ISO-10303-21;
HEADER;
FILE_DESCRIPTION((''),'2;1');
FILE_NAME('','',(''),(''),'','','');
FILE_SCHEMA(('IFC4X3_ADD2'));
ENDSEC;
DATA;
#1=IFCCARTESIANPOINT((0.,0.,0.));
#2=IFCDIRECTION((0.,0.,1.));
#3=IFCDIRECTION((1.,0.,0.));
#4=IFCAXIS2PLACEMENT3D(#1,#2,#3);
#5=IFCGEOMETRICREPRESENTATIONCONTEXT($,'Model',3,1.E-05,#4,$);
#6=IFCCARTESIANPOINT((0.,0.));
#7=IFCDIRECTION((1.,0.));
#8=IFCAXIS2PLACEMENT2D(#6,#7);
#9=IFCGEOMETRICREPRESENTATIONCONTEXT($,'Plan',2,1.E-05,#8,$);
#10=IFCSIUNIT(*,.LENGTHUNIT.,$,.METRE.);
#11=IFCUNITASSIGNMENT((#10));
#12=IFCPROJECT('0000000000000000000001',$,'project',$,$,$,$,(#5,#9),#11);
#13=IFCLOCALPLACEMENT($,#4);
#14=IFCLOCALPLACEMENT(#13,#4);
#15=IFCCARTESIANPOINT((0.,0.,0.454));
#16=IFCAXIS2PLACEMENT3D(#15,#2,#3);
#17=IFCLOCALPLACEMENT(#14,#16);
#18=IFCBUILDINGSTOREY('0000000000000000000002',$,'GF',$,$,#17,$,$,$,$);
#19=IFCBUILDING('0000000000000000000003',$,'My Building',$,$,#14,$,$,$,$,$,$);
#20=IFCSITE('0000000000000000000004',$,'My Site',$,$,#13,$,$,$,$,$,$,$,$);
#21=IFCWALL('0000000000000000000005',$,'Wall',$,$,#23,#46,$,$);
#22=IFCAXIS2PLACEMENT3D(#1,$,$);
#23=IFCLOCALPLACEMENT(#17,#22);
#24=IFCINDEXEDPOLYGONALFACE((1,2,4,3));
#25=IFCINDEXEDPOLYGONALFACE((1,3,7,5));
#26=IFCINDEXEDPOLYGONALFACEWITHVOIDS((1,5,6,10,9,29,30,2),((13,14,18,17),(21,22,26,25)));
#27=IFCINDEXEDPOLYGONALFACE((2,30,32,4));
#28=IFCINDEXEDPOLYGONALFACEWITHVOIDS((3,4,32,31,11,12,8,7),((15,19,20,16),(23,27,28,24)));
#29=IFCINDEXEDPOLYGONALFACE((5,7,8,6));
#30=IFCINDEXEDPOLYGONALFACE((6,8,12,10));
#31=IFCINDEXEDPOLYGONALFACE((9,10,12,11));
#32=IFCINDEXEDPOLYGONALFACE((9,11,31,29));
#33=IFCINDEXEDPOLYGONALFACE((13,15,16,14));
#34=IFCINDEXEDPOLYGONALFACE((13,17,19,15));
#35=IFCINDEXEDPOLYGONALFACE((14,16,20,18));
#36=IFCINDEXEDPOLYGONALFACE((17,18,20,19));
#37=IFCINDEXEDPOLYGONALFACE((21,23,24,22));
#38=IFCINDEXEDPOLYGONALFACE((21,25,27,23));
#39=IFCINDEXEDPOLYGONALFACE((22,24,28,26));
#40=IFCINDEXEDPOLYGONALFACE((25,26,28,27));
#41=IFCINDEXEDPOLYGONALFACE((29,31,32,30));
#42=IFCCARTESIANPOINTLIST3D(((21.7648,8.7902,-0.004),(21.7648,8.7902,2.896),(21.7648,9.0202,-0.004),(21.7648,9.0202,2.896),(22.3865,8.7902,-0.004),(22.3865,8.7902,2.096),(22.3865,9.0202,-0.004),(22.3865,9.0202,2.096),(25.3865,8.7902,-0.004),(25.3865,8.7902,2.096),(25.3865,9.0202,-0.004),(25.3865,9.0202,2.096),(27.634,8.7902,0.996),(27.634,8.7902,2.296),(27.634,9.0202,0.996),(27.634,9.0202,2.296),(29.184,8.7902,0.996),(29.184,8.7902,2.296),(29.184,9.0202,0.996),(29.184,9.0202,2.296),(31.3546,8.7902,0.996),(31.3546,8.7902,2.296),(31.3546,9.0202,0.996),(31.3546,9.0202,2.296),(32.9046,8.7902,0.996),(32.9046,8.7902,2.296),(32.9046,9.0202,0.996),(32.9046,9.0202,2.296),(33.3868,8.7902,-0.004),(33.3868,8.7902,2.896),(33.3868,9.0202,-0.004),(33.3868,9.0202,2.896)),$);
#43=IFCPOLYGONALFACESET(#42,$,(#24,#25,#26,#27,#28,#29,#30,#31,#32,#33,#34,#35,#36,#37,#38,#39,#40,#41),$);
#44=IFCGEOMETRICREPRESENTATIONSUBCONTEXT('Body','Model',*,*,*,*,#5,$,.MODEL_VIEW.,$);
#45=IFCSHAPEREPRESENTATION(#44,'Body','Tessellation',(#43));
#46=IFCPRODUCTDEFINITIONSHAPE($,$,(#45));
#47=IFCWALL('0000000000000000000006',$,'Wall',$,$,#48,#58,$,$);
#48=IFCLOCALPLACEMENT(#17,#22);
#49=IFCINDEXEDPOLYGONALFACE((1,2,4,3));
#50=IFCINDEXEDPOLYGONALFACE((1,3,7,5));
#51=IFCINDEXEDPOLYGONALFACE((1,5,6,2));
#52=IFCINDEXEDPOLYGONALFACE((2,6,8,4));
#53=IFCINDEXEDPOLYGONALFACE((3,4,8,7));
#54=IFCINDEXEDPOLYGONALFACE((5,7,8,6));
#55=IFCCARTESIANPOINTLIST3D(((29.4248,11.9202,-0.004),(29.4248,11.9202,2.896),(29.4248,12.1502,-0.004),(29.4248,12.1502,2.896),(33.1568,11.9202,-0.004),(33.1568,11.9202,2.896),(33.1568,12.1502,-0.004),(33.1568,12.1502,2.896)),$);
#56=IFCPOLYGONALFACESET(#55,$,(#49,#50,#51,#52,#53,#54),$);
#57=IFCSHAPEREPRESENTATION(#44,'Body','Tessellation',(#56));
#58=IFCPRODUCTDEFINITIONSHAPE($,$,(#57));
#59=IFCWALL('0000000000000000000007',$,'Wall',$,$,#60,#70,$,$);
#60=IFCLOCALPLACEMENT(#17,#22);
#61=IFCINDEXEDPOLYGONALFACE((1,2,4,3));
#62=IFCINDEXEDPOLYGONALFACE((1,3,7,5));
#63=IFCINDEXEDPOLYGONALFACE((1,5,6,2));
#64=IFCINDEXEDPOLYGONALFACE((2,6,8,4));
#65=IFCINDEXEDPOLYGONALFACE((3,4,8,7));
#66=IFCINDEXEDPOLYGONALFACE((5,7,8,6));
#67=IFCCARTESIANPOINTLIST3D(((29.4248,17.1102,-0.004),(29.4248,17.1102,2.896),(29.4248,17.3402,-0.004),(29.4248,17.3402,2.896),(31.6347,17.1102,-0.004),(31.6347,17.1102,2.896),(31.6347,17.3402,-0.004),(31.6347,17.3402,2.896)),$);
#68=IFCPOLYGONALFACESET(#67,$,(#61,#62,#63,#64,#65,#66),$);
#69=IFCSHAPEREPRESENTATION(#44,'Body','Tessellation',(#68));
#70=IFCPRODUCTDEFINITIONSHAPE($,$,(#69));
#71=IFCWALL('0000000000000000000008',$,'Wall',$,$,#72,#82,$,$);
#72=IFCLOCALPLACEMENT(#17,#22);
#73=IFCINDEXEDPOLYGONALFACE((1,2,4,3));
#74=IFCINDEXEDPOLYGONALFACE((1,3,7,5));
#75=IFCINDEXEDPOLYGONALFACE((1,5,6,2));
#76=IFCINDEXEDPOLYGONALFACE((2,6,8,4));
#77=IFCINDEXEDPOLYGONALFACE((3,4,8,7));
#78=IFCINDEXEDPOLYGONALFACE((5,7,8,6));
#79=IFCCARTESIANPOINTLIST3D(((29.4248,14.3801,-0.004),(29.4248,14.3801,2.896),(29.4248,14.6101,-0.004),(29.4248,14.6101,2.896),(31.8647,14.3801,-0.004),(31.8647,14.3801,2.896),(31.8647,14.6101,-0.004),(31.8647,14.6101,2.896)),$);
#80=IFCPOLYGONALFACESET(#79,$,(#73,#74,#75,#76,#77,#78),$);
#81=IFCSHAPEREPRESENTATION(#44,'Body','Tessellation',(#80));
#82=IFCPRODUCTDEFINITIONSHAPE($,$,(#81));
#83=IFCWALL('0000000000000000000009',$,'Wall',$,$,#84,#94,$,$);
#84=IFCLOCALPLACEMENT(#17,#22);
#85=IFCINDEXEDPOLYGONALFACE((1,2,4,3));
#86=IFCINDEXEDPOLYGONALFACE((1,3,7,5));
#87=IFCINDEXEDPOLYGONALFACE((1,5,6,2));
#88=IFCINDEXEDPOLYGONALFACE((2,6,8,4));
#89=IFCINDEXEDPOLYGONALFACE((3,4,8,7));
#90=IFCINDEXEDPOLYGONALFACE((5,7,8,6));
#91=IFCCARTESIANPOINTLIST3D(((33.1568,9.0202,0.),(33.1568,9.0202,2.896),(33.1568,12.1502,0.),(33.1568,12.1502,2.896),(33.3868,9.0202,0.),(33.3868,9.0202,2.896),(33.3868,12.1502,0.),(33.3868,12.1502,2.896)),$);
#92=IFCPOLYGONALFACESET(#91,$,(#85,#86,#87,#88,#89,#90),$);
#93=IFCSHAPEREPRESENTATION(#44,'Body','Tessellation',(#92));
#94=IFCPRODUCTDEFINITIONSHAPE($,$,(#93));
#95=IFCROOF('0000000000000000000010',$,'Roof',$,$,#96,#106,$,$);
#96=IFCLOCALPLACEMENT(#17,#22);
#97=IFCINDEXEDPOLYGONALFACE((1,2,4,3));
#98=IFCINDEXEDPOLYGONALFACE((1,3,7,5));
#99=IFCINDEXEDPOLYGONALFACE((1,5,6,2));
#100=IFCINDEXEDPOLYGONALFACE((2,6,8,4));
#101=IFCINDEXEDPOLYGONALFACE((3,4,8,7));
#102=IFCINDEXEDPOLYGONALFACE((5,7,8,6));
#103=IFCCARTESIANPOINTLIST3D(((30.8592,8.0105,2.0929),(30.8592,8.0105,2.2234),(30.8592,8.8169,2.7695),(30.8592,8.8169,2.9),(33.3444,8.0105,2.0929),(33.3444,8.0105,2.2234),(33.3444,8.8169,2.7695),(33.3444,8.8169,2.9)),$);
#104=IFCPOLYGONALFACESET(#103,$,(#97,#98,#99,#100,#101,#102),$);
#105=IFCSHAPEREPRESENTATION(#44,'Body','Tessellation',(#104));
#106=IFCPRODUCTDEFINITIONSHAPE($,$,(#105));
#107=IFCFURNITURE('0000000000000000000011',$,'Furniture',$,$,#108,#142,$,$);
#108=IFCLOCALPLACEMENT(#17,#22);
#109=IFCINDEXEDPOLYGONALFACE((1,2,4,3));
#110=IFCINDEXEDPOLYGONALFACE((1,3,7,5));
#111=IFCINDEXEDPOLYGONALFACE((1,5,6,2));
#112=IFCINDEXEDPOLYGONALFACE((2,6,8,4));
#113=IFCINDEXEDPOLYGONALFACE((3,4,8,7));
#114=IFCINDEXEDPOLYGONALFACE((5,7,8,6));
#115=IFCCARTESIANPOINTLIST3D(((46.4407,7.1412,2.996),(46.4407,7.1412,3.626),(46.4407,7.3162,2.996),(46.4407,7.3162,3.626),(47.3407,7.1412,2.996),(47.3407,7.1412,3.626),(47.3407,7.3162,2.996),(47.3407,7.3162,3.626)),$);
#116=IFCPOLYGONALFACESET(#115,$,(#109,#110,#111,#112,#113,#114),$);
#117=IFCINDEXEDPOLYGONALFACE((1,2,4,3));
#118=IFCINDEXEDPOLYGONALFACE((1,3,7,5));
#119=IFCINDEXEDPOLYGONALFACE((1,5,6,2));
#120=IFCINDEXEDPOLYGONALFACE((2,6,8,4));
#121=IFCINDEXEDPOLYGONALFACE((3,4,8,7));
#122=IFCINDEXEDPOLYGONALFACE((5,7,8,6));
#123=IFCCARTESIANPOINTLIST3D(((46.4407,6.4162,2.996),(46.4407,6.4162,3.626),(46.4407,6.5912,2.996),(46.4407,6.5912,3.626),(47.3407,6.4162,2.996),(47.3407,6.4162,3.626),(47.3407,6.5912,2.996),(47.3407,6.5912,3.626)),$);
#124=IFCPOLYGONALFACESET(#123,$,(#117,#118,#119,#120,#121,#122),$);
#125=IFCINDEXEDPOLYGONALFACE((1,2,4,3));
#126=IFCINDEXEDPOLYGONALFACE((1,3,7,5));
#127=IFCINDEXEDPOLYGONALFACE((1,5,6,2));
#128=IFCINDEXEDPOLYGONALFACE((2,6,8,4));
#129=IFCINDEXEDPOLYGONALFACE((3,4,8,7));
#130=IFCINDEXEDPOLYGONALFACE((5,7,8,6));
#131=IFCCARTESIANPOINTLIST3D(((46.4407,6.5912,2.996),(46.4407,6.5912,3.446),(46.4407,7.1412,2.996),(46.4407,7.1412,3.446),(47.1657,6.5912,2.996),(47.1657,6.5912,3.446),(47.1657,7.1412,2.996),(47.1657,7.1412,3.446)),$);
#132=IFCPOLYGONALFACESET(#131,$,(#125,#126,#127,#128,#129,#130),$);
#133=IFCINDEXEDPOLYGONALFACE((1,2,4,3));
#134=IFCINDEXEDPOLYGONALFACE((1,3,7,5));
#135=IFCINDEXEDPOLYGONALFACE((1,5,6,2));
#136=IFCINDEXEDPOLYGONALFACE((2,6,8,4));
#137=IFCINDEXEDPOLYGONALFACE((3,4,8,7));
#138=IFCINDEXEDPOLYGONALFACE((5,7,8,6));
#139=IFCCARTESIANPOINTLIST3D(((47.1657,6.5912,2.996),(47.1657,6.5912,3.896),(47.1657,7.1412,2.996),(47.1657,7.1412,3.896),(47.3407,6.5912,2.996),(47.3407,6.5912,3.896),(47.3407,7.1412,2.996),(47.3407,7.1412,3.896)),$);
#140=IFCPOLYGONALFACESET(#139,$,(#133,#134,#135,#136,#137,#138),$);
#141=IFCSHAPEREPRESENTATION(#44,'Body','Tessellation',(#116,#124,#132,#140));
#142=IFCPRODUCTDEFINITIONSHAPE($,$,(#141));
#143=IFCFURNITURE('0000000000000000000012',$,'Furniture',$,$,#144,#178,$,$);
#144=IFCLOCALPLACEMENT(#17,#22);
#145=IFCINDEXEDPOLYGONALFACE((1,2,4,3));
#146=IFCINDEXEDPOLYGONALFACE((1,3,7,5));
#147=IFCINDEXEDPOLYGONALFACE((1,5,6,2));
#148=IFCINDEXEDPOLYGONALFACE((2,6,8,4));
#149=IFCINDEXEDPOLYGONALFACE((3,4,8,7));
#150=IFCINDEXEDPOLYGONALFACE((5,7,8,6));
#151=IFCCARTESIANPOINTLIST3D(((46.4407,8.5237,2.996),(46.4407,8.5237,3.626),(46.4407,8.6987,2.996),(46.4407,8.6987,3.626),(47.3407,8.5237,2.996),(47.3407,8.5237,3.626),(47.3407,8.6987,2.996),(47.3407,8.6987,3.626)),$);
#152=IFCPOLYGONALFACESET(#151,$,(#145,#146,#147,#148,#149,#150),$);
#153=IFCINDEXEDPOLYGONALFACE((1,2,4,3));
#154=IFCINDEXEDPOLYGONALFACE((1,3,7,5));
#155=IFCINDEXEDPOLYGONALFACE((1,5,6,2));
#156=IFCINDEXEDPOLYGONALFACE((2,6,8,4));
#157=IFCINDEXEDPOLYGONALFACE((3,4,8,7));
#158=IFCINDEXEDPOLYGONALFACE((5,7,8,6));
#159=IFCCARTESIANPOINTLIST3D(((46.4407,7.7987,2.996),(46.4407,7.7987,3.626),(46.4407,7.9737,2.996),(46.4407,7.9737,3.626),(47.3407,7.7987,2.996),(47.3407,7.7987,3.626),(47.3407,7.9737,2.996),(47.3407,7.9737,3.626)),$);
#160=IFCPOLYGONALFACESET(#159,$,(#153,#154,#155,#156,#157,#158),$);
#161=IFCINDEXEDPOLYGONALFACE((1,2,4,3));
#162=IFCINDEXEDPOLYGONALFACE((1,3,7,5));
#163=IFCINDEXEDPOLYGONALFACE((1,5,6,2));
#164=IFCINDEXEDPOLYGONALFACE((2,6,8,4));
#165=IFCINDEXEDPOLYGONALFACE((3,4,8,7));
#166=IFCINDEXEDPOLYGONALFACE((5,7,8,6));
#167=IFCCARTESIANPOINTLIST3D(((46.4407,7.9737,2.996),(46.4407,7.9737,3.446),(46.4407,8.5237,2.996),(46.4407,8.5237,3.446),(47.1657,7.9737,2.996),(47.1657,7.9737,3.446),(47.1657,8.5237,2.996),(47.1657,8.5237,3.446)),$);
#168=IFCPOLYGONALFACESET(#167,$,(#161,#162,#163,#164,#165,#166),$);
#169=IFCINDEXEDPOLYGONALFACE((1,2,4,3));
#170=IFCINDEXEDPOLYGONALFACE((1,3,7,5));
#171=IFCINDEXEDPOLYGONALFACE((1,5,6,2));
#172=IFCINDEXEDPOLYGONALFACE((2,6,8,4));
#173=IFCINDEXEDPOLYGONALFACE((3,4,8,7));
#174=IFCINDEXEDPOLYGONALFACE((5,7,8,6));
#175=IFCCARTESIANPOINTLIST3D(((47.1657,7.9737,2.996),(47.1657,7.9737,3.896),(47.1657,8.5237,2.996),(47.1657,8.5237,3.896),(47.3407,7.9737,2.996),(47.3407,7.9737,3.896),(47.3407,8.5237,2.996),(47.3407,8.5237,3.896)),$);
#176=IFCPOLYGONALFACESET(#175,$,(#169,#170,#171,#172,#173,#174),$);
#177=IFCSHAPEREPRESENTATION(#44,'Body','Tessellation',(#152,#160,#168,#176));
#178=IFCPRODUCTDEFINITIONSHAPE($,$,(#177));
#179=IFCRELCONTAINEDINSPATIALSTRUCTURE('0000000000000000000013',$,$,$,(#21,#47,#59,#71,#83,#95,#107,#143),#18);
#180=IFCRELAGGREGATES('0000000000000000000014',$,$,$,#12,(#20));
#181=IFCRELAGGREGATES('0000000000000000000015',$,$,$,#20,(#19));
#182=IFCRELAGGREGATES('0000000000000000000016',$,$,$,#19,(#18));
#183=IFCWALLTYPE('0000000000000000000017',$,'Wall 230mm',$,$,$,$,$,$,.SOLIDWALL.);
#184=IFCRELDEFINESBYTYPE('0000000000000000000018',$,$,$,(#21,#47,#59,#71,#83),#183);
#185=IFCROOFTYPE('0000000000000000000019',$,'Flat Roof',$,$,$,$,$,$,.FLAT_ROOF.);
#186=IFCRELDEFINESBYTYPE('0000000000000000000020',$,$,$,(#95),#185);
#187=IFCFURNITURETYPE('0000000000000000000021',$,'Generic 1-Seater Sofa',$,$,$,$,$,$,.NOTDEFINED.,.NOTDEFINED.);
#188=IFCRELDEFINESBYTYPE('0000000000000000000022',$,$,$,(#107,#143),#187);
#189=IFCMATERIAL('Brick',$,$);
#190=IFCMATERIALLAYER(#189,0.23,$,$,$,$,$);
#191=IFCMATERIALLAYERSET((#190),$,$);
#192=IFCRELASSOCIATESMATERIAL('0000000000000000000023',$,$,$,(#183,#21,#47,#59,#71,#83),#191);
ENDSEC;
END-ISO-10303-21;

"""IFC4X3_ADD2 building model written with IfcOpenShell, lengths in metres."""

from ifc_helpers import new_model, entity, si_unit, frame, origin_with_axes, origin_2d_with_axis, place, context, subcontext, project, spatial, polyline, line, indexed_curve, outline, extrude, clip, halfspace, shape, source, transform, mapped, material, layer, layer_set, layer_usage, type_object, type_shapes, element, save


model = new_model("IFC4X3_ADD2")

# Units and contexts
model_context = context("Model", 3, precision=1e-05, world=origin_with_axes())
plan_context = context("Plan", 2, precision=1e-05, world=origin_2d_with_axis())
body_context_1 = subcontext(model_context, "Body", "Model", "MODEL_VIEW")
body_context_2 = subcontext(plan_context, "Body", "Plan", "PLAN_VIEW")
ifc_project = project(units=[si_unit("LENGTHUNIT", "METRE")], contexts=[model_context, plan_context])

# Site, building, storey
site_placement = place(None, origin_with_axes())
site = spatial("IfcSite", under=ifc_project, at=site_placement, Name="My Site")
building_placement = place(site_placement, origin_with_axes())
building = spatial("IfcBuilding", under=site, at=building_placement, Name="My Building")
storey_placement = place(building_placement, frame((0.0, 0.0, 0.454), z_axis=(0.0, 0.0, 1.0), x_axis=(1.0, 0.0, 0.0)))
storey = spatial("IfcBuildingStorey", under=building, at=storey_placement, Name="GF")

# Shared definitions
ifc_material = material(Name="Brick")
ifc_layer = layer(ifc_material, 0.23)
ifc_layer_set = layer_set([ifc_layer])
wall_type = type_object("IfcWallType", Name="Wall 230mm", PredefinedType="SOLIDWALL", material=ifc_layer_set)

# Wall, openings
ifc_layer_usage_1 = layer_usage(ifc_layer_set, "AXIS2", "POSITIVE", 0.0)
wall_1_placement = place(storey_placement, frame((33.3868, 9.0202, -0.004), z_axis=(0.0, 0.0, 1.0), x_axis=(-1.0, 0.0, 0.0)))
wall_1 = element("IfcWall", 1, at=wall_1_placement, inside=storey, type_object=wall_type, material=ifc_layer_usage_1, Name="Wall", context=body_context_1, shape_type="SweptSolid", body=[
    extrude(outline(indexed_curve([(0.0, 0.0), (0.0, 0.23), (11.622, 0.23), (11.622, 0.0), (0.0, 0.0)], self_intersect=False)), origin_with_axes(), (0.0, 0.0, 1.0), 2.9),
])
shared_shape_1 = source(origin_with_axes(), body_context_1, "Body", "SweptSolid", [
    extrude(outline(indexed_curve([(0.0, 0.0), (3.0, 0.0), (3.0, 2.1), (0.0, 2.1)], segments=[line(1, 2, 3, 4, 1)])), frame((0.0, -0.6, 0.0), z_axis=(0.0, -1.0, 0.0), x_axis=(1.0, 0.0, 0.0)), (0.0, 0.0, -1.0), 1.2),
])
opening_1_placement = place(wall_1_placement, frame((8.0003, 0.0, 0.0), z_axis=(0.0, 0.0, 1.0), x_axis=(1.0, 0.0, 0.0)))
element("IfcOpeningElement", 2, at=opening_1_placement, cuts=wall_1, PredefinedType="OPENING", context=body_context_1, shape_type="MappedRepresentation", body=[
    mapped(shared_shape_1, transform((0.0, 0.0, 0.0), x_axis=(1.0, 0.0, 0.0), y_axis=(0.0, 1.0, 0.0), z_axis=(0.0, 0.0, 1.0), scale=1.0)),
])
shared_shape_2 = source(origin_with_axes(), body_context_1, "Body", "SweptSolid", [
    extrude(outline(indexed_curve([(0.0, 0.0), (1.55, 0.0), (1.55, 1.3), (0.0, 1.3)], segments=[line(1, 2, 3, 4, 1)])), frame((-0.775, -0.6, 0.0), z_axis=(0.0, -1.0, 0.0), x_axis=(1.0, 0.0, 0.0)), (0.0, 0.0, -1.0), 1.2),
])
opening_2_placement = place(wall_1_placement, frame((1.2571, 0.0, 1.0), z_axis=(0.0, 0.0, 1.0), x_axis=(1.0, 0.0, 0.0)))
element("IfcOpeningElement", 3, at=opening_2_placement, cuts=wall_1, PredefinedType="OPENING", context=body_context_1, shape_type="MappedRepresentation", body=[
    mapped(shared_shape_2, transform((0.0, 0.0, 0.0), x_axis=(1.0, 0.0, 0.0), y_axis=(0.0, 1.0, 0.0), z_axis=(0.0, 0.0, 1.0), scale=1.0)),
])
opening_3_placement = place(wall_1_placement, frame((4.9778, 0.0, 1.0), z_axis=(0.0, 0.0, 1.0), x_axis=(1.0, 0.0, 0.0)))
element("IfcOpeningElement", 4, at=opening_3_placement, cuts=wall_1, PredefinedType="OPENING", context=body_context_1, shape_type="MappedRepresentation", body=[
    mapped(shared_shape_2, transform((0.0, 0.0, 0.0), x_axis=(1.0, 0.0, 0.0), y_axis=(0.0, 1.0, 0.0), z_axis=(0.0, 0.0, 1.0), scale=1.0)),
])

# Walls
ifc_layer_usage_2 = layer_usage(ifc_layer_set, "AXIS2", "POSITIVE", 0.0)
wall_2_placement = place(storey_placement, frame((33.1568, 12.1502, -0.004), z_axis=(0.0, 0.0, 1.0), x_axis=(-1.0, 0.0, 0.0)))
element("IfcWall", 5, at=wall_2_placement, inside=storey, type_object=wall_type, material=ifc_layer_usage_2, Name="Wall", context=body_context_1, shape_type="SweptSolid", body=[
    extrude(outline(indexed_curve([(0.0, 0.0), (0.0, 0.23), (3.732, 0.23), (3.732, 0.0), (0.0, 0.0)], self_intersect=False)), origin_with_axes(), (0.0, 0.0, 1.0), 2.9),
])
ifc_layer_usage_3 = layer_usage(ifc_layer_set, "AXIS2", "POSITIVE", 0.0)
wall_3_placement = place(storey_placement, frame((31.6347, 17.3402, -0.004), z_axis=(0.0, 0.0, 1.0), x_axis=(-1.0, 0.0, 0.0)))
element("IfcWall", 6, at=wall_3_placement, inside=storey, type_object=wall_type, material=ifc_layer_usage_3, Name="Wall", context=body_context_1, shape_type="SweptSolid", body=[
    extrude(outline(indexed_curve([(0.0, 0.0), (0.0, 0.23), (2.21, 0.23), (2.21, 0.0), (0.0, 0.0)], self_intersect=False)), origin_with_axes(), (0.0, 0.0, 1.0), 2.9),
])
ifc_layer_usage_4 = layer_usage(ifc_layer_set, "AXIS2", "POSITIVE", 0.0)
wall_4_placement = place(storey_placement, frame((31.8647, 14.6101, -0.004), z_axis=(0.0, 0.0, 1.0), x_axis=(-1.0, 0.0, 0.0)))
element("IfcWall", 7, at=wall_4_placement, inside=storey, type_object=wall_type, material=ifc_layer_usage_4, Name="Wall", context=body_context_1, shape_type="SweptSolid", body=[
    extrude(outline(indexed_curve([(0.0, 0.0), (0.0, 0.23), (2.44, 0.23), (2.44, 0.0), (0.0, 0.0)], self_intersect=False)), origin_with_axes(), (0.0, 0.0, 1.0), 2.9),
])
ifc_layer_usage_5 = layer_usage(ifc_layer_set, "AXIS2", "POSITIVE", 0.0)
wall_5_placement = place(storey_placement, frame((33.3868, 9.0202, 0.0), z_axis=(0.0, 0.0, 1.0), x_axis=(0.000001, 1.0, 0.0)))
element("IfcWall", 8, at=wall_5_placement, inside=storey, type_object=wall_type, material=ifc_layer_usage_5, Name="Wall", context=body_context_1, shape_type="Clipping", body=[
    clip(extrude(outline(indexed_curve([(0.0, 0.0), (0.0, 0.23), (3.13, 0.23), (3.13, 0.0), (0.0, 0.0)], self_intersect=False)), origin_with_axes(), (0.0, 0.0, 1.0), 3.35), halfspace(frame((0.0, 0.0, 2.896), z_axis=(0.0, 0.0, 1.0), x_axis=(-1.0, 0.0, 0.0)), False)),
])

# Roof
roof_type = type_object("IfcRoofType", Name="Flat Roof", PredefinedType="FLAT_ROOF")
roof_placement = place(storey_placement, frame((30.8592, 8.0241, 2.1043), z_axis=(0.0, -0.642788, 0.766044), x_axis=(1.0, 0.0, 0.0)))
element("IfcRoof", 9, at=roof_placement, inside=storey, type_object=roof_type, Name="Roof", context=body_context_1, shape_type="SweptSolid", body=[
    extrude(outline(polyline([(-1.2426, -0.0653), (1.2426, -0.0653), (1.2426, 0.0653), (-1.2426, 0.0653), (-1.2426, -0.0653)])), frame((1.2426, 1.0768, 0.05), z_axis=(0.0, 0.766044, -0.642788), x_axis=(1.0, 0.0, 0.0)), (0.0, 0.642788, -0.766044), 1.0526),
])

# Furniture
furniture_type_1 = type_object("IfcFurnitureType", Name="Generic 1-Seater Sofa", AssemblyPlace="NOTDEFINED", PredefinedType="NOTDEFINED")
shared_shape_3 = source(origin_with_axes(), body_context_1, "Body", "SweptSolid", [
    extrude(outline(indexed_curve([(0.0, 0.0), (0.175, 0.0), (0.175, 0.9), (0.0, 0.9)], segments=[line(4, 1), line(1, 2), line(2, 3), line(3, 4)], self_intersect=False)), frame((-0.45, -0.9, 0.0), z_axis=(0.0, 0.0, 1.0), x_axis=(1.0, 0.0, 0.0)), (0.0, 0.0, 1.0), 0.63),
    extrude(outline(indexed_curve([(0.0, 0.0), (0.175, 0.0), (0.175, 0.9), (0.0, 0.9)], segments=[line(1, 2, 3, 4, 1)])), frame((0.275, -0.9, 0.0), z_axis=(0.0, 0.0, 1.0), x_axis=(1.0, 0.0, 0.0)), (0.0, 0.0, 1.0), 0.63),
    extrude(outline(indexed_curve([(0.175, 0.0), (0.725, 0.0), (0.725, 0.725), (0.175, 0.725)], segments=[line(1, 2, 3, 4, 1)])), frame((-0.45, -0.9, 0.0), z_axis=(0.0, 0.0, 1.0), x_axis=(1.0, 0.0, 0.0)), (0.0, 0.0, 1.0), 0.45),
    extrude(outline(indexed_curve([(0.175, 0.725), (0.725, 0.725), (0.725, 0.9), (0.175, 0.9)], segments=[line(1, 2, 3, 4, 1)])), frame((-0.45, -0.9, 0.0), z_axis=(0.0, 0.0, 1.0), x_axis=(1.0, 0.0, 0.0)), (0.0, 0.0, 1.0), 0.9),
])
shared_shape_4 = source(origin_with_axes(), body_context_2, "Body", "Annotation2D", [
    entity("IfcGeometricCurveSet", [entity("IfcIndexedPolyCurve", entity("IfcCartesianPointList2D", [[0.275, -0.175], [0.275, -0.9], [0.45, -0.9], [0.45, 0.0], [0.275, 0.0], [0.275, -0.9], [-0.275, -0.9], [-0.275, 0.0], [-0.275, -0.175], [0.275, -0.175], [0.275, 0.0], [-0.275, 0.0], [-0.45, 0.0], [-0.45, -0.9], [-0.275, -0.9], [-0.275, -0.175]]))]),
])
type_shapes(furniture_type_1, [shared_shape_3, shared_shape_4])
for number, where, z_axis, x_axis, name in (
    (10, (47.3407, 6.8662, 2.996), (0.0, 0.0, 1.0), (0.0, -1.0, 0.0), "Furniture"),
    (11, (47.3407, 8.2487, 2.996), (0.0, 0.0, 1.0), (0.0, -1.0, 0.0), "Furniture"),
):
    element("IfcFurniture", number, at=place(storey_placement, frame(where, z_axis=z_axis, x_axis=x_axis)), inside=storey, type_object=furniture_type_1, Name=name, shapes=[
        shape(body_context_1, "Body", "MappedRepresentation", [mapped(shared_shape_3, transform((0.0, 0.0, 0.0), x_axis=(1.0, 0.0, 0.0), y_axis=(0.0, 1.0, 0.0), z_axis=(0.0, 0.0, 1.0), scale=1.0))]),
        shape(body_context_2, "Body", "MappedRepresentation", [mapped(shared_shape_4, transform((0.0, 0.0, 0.0), x_axis=(1.0, 0.0, 0.0), y_axis=(0.0, 1.0, 0.0), z_axis=(0.0, 0.0, 1.0), scale=1.0))]),
    ])

save(model, "model.ifc")
